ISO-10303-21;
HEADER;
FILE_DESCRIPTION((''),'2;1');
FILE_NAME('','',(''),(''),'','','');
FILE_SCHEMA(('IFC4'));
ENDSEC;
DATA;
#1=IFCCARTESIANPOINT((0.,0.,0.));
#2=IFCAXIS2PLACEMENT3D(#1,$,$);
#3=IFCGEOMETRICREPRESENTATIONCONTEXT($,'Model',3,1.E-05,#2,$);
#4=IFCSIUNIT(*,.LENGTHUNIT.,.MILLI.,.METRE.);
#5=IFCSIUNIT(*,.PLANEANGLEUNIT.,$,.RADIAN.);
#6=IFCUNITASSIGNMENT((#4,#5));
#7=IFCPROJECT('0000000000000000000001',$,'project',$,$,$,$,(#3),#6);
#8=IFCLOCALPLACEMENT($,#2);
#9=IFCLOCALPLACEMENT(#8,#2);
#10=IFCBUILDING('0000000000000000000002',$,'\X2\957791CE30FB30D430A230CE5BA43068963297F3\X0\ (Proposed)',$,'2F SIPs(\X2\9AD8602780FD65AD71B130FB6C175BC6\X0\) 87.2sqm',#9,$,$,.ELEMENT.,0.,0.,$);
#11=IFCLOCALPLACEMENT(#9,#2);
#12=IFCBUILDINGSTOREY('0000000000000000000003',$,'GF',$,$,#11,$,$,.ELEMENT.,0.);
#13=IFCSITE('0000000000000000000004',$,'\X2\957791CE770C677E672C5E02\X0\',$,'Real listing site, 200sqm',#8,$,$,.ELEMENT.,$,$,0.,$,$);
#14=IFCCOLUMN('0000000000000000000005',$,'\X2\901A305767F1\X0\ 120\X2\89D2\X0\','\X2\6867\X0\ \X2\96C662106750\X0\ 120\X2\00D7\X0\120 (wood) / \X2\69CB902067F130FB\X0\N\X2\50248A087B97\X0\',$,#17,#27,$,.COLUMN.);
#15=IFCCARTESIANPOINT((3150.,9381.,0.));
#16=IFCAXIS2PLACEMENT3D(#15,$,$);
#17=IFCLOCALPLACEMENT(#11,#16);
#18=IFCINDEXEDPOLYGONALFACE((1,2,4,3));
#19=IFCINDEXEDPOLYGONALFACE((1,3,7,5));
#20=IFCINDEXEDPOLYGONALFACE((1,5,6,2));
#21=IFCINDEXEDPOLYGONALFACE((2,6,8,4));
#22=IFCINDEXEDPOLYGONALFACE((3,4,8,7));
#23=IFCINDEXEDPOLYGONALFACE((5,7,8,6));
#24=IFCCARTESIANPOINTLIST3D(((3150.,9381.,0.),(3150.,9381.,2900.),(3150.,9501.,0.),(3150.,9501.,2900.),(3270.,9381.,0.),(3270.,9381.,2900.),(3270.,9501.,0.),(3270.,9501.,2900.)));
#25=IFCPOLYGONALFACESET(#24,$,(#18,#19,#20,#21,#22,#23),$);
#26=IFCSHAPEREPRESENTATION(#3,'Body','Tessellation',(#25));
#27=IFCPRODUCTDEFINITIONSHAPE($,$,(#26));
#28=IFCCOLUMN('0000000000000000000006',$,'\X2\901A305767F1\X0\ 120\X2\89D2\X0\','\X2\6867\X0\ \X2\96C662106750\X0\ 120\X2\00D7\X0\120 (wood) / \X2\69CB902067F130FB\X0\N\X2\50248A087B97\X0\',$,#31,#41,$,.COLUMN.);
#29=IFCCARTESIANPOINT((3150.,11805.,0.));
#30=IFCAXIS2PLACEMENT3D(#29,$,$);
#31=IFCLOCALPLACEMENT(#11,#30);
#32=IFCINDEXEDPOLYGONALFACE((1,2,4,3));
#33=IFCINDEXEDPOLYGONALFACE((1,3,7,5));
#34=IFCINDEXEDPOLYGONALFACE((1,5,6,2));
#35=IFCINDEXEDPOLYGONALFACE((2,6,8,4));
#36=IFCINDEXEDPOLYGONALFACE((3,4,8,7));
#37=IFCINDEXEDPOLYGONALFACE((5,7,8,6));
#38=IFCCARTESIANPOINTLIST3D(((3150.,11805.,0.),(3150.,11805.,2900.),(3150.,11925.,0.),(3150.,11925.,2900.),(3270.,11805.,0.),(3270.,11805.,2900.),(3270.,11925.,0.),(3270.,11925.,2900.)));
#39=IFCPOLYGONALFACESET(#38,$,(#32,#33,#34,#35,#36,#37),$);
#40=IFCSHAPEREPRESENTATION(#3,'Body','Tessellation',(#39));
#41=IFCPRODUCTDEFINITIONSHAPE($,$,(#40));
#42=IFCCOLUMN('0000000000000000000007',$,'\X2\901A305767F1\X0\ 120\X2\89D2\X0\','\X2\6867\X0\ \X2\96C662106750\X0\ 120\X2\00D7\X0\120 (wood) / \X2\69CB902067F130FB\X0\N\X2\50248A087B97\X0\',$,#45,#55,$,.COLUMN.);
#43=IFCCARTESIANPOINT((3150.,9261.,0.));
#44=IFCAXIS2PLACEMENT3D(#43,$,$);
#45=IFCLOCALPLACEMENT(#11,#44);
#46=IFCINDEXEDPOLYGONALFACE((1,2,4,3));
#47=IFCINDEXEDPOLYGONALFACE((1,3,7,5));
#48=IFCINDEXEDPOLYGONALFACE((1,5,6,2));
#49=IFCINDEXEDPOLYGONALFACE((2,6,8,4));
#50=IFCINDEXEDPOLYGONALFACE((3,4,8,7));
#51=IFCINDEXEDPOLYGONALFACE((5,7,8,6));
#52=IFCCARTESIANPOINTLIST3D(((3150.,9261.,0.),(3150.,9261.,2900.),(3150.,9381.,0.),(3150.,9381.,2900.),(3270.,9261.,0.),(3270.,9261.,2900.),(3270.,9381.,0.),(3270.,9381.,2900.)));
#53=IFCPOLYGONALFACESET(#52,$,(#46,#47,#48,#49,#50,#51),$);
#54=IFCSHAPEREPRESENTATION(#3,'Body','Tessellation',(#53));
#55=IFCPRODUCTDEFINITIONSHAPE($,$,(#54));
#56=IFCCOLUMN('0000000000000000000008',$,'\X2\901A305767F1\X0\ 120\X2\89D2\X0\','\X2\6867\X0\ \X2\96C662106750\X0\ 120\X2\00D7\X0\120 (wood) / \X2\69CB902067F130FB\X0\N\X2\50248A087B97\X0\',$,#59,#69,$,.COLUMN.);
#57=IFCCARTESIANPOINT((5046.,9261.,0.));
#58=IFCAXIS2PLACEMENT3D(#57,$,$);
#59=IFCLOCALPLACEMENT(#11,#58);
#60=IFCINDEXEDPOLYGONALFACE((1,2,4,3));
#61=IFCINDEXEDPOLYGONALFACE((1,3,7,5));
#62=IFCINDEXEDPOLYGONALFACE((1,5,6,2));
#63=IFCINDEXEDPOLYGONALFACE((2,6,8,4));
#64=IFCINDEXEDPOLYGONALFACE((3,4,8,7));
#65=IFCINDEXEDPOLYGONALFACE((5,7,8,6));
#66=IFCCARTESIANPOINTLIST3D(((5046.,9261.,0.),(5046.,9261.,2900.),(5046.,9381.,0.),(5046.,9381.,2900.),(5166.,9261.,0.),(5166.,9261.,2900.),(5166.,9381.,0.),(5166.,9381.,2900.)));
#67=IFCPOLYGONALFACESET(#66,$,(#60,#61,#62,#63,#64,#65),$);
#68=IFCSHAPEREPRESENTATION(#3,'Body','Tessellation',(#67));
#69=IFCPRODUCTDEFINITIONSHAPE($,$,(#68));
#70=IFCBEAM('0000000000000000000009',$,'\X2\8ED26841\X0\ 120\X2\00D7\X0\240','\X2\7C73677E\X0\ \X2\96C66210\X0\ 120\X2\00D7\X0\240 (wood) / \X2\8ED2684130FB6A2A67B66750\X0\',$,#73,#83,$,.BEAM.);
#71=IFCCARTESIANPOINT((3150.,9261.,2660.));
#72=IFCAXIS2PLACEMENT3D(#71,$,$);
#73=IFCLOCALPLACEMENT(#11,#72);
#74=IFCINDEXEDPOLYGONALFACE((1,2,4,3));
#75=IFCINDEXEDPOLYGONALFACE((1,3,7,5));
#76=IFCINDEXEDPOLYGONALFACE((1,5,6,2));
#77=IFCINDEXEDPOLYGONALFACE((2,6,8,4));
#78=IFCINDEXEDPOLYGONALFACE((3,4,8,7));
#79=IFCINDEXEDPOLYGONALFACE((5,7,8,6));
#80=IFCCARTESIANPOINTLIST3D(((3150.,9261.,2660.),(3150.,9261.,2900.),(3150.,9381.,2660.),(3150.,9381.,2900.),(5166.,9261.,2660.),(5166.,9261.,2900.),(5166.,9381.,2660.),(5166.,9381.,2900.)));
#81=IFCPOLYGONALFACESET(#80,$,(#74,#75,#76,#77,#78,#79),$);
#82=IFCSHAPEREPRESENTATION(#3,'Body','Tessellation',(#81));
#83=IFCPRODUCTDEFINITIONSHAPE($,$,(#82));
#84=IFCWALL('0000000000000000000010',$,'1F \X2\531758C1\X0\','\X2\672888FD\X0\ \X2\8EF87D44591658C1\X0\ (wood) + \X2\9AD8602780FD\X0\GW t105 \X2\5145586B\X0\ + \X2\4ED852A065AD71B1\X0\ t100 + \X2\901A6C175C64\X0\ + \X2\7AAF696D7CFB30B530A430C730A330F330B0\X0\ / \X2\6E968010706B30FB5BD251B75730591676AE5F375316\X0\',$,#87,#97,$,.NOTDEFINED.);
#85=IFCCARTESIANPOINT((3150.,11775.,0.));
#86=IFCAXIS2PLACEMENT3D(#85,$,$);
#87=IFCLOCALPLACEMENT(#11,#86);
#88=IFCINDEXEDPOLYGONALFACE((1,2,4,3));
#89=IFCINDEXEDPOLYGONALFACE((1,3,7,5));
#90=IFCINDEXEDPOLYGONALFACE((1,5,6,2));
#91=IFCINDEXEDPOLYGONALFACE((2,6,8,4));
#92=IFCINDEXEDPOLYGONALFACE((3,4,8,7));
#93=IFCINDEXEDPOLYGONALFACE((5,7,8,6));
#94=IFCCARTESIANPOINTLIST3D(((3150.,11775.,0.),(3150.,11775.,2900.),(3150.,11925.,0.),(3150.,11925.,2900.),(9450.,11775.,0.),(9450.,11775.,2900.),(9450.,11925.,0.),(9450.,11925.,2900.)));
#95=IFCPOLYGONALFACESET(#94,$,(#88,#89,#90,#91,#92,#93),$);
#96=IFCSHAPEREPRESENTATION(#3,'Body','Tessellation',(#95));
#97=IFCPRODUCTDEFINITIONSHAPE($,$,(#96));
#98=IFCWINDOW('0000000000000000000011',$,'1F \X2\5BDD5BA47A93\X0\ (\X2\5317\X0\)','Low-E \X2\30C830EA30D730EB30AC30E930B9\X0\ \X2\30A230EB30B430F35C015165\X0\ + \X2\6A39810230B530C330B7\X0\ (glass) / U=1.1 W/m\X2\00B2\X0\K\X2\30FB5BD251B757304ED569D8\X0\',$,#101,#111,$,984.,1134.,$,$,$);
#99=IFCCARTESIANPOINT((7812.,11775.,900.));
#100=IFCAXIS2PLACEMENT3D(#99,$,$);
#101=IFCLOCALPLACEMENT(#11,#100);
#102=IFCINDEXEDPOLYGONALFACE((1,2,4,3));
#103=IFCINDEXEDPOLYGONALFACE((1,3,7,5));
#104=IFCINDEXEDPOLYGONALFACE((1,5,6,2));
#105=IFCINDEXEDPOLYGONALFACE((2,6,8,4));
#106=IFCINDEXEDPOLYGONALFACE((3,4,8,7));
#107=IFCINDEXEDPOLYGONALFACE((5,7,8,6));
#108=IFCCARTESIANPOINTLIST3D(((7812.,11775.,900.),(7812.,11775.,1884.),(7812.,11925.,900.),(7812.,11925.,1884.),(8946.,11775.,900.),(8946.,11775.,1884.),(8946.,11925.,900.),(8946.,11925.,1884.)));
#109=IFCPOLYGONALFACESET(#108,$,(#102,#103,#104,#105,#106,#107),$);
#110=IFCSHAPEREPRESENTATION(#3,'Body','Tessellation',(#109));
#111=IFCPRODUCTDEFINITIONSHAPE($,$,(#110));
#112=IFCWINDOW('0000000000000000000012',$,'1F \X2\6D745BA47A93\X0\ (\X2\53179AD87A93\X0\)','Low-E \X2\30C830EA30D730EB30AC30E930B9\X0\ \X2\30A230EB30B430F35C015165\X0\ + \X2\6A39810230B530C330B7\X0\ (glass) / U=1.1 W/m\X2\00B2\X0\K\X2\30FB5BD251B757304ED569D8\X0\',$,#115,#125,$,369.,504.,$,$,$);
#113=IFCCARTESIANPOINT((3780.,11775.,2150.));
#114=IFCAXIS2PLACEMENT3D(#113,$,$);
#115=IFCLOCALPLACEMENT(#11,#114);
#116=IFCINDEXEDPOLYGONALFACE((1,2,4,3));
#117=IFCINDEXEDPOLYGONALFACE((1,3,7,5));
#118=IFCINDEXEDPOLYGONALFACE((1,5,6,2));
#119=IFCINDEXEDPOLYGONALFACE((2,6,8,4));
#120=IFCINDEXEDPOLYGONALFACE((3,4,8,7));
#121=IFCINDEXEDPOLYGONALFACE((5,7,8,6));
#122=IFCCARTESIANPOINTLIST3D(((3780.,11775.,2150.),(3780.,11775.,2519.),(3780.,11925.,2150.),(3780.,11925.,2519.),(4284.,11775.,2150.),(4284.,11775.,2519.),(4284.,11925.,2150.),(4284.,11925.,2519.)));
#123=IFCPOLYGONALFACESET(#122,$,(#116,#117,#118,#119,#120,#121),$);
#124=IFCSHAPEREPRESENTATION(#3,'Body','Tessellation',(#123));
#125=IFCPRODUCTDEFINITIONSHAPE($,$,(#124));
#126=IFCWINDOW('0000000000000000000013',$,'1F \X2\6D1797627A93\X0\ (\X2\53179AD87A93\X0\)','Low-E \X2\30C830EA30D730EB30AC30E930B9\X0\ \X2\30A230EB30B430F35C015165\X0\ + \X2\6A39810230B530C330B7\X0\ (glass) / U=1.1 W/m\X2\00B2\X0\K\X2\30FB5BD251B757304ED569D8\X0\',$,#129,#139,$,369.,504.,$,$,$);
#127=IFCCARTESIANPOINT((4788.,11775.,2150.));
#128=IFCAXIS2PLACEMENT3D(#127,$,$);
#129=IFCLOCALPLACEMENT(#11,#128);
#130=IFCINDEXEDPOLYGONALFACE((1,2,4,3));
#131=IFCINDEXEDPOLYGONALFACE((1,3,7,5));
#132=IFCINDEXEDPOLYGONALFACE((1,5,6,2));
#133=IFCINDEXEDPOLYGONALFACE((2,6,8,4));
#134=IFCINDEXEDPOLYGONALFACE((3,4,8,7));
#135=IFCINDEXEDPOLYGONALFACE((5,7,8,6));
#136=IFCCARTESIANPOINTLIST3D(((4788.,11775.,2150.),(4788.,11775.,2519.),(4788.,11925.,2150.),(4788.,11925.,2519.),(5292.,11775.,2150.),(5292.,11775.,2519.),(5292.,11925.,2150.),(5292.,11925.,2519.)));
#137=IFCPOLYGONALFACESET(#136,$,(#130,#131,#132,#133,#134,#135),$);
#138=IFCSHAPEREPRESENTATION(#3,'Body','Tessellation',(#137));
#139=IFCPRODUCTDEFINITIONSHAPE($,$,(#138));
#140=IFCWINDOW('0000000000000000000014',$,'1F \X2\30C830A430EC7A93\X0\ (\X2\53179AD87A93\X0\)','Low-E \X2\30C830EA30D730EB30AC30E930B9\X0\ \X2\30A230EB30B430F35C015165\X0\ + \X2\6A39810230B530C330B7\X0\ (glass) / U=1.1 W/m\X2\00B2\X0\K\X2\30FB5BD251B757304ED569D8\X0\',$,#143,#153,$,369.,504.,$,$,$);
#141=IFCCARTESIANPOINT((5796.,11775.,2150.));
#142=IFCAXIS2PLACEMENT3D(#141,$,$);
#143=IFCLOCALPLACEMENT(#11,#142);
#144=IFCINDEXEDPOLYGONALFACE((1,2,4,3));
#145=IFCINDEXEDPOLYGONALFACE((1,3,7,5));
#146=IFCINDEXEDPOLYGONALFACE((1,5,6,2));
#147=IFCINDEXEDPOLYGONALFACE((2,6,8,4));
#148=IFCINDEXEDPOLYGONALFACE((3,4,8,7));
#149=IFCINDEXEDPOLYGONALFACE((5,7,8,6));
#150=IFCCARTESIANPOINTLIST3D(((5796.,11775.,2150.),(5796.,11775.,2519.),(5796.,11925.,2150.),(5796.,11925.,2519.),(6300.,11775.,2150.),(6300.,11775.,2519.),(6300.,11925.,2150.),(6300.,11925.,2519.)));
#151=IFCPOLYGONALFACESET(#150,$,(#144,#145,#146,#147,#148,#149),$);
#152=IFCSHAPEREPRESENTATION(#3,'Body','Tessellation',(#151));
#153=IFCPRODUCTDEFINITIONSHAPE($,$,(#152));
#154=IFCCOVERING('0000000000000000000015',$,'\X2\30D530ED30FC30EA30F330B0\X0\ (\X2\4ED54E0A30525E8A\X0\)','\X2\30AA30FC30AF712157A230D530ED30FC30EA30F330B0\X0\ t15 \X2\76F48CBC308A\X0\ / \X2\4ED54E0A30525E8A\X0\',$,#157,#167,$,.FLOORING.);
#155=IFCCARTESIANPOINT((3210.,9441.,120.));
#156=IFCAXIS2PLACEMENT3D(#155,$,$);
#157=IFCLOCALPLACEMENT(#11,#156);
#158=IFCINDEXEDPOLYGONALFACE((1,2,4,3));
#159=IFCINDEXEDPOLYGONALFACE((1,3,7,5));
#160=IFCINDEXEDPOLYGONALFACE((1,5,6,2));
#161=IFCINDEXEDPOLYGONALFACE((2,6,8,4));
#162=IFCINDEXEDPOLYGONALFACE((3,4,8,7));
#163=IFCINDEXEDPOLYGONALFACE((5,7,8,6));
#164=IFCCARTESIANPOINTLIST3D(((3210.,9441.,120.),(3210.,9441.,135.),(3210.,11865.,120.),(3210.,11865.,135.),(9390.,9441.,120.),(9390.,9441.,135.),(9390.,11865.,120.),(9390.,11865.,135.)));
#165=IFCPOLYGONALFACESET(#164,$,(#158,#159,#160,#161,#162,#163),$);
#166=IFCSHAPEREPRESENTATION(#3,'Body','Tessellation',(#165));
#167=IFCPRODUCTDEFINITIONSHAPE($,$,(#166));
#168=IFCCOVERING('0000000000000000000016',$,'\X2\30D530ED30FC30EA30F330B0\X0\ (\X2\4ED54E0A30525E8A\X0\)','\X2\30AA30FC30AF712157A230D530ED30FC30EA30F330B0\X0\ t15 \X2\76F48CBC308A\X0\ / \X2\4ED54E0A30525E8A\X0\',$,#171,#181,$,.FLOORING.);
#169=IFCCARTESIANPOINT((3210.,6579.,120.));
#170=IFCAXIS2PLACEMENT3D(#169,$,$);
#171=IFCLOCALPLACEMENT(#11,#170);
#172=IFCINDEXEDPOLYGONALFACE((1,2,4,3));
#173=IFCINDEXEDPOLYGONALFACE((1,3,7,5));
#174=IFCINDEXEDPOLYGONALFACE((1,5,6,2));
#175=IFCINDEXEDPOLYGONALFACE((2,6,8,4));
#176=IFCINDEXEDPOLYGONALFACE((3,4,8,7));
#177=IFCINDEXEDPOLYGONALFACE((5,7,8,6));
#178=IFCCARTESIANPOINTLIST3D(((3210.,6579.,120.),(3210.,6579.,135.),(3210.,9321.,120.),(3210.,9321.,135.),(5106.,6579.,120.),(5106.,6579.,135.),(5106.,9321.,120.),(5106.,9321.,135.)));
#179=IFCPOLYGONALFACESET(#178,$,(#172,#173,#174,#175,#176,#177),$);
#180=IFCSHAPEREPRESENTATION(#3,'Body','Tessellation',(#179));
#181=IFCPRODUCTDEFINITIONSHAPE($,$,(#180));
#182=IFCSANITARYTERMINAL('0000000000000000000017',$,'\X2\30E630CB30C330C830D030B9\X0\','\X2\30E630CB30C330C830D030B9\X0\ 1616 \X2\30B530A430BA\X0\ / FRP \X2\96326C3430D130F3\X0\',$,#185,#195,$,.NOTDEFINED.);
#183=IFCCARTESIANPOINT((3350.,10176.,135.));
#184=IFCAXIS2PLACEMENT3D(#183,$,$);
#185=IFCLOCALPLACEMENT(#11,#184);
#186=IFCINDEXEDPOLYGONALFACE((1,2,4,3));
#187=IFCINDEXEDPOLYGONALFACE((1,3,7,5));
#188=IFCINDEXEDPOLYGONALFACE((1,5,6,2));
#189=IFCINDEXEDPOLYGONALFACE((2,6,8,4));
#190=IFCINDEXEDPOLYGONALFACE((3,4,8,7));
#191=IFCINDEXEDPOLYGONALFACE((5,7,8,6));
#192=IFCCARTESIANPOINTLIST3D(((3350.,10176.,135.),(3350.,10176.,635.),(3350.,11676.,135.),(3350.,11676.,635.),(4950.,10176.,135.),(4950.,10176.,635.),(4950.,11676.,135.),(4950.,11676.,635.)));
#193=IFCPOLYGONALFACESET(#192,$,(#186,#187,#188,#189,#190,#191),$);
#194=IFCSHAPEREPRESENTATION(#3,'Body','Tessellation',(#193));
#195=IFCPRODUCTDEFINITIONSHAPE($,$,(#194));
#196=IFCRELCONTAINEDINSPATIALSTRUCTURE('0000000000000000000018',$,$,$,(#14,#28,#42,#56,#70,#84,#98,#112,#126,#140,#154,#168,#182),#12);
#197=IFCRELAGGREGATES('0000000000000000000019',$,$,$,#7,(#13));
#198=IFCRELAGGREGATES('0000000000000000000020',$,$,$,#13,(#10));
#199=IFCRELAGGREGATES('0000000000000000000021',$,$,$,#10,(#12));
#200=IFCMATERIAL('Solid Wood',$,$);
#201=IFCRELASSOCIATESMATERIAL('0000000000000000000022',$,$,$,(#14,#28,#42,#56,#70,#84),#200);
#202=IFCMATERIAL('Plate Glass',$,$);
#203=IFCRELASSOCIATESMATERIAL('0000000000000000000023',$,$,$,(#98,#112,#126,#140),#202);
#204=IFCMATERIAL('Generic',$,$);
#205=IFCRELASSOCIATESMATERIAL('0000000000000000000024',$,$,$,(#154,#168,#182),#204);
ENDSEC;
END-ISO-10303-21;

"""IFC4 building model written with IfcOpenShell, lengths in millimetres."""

from ifc_helpers import new_model, si_unit, frame, frame_2d, origin, place, context, project, spatial, rectangle, extrude, material, element, fill, save


model = new_model("IFC4")

# Units and contexts
model_context = context("Model", 3, precision=1e-05, world=origin())
ifc_project = project(units=[si_unit("LENGTHUNIT", "METRE", prefix="MILLI"), si_unit("PLANEANGLEUNIT", "RADIAN")], contexts=[model_context])

# Site, building, storey
site_placement = place(None, origin())
site = spatial("IfcSite", under=ifc_project, at=site_placement, Name="長野県松本市", ObjectType="Real listing site, 200sqm", CompositionType="ELEMENT", RefElevation=0.0)
building_placement = place(site_placement, origin())
building = spatial("IfcBuilding", under=site, at=building_placement, Name="長野・ピアノ室と防音 (Proposed)", ObjectType="2F SIPs(高性能断熱・気密) 87.2sqm", CompositionType="ELEMENT", ElevationOfRefHeight=0.0, ElevationOfTerrain=0.0)
storey_placement = place(building_placement, origin())
storey = spatial("IfcBuildingStorey", under=building, at=storey_placement, Name="GF", CompositionType="ELEMENT", Elevation=0.0)

# Columns
ifc_material_1 = material(Name="Solid Wood")
column_1_placement = place(storey_placement, frame((3150.0, 9381.0, 0.0)))
element("IfcColumn", 1, at=column_1_placement, inside=storey, material=ifc_material_1, Name="通し柱 120角", Description="桧 集成材 120×120 (wood) / 構造柱・N値計算", PredefinedType="COLUMN", context=model_context, shape_type="SweptSolid", body=[
    extrude(rectangle(XDim=120.0, YDim=120.0, at=frame_2d((60.0, 60.0))), frame((3150.0, 9381.0, 0.0)), (0.0, 0.0, 1.0), 2900.0),
])
column_2_placement = place(storey_placement, frame((3150.0, 11805.0, 0.0)))
element("IfcColumn", 2, at=column_2_placement, inside=storey, material=ifc_material_1, Name="通し柱 120角", Description="桧 集成材 120×120 (wood) / 構造柱・N値計算", PredefinedType="COLUMN", context=model_context, shape_type="SweptSolid", body=[
    extrude(rectangle(XDim=120.0, YDim=120.0, at=frame_2d((60.0, 60.0))), frame((3150.0, 11805.0, 0.0)), (0.0, 0.0, 1.0), 2900.0),
])
column_3_placement = place(storey_placement, frame((3150.0, 9261.0, 0.0)))
element("IfcColumn", 3, at=column_3_placement, inside=storey, material=ifc_material_1, Name="通し柱 120角", Description="桧 集成材 120×120 (wood) / 構造柱・N値計算", PredefinedType="COLUMN", context=model_context, shape_type="SweptSolid", body=[
    extrude(rectangle(XDim=120.0, YDim=120.0, at=frame_2d((60.0, 60.0))), frame((3150.0, 9261.0, 0.0)), (0.0, 0.0, 1.0), 2900.0),
])
column_4_placement = place(storey_placement, frame((5046.0, 9261.0, 0.0)))
element("IfcColumn", 4, at=column_4_placement, inside=storey, material=ifc_material_1, Name="通し柱 120角", Description="桧 集成材 120×120 (wood) / 構造柱・N値計算", PredefinedType="COLUMN", context=model_context, shape_type="SweptSolid", body=[
    extrude(rectangle(XDim=120.0, YDim=120.0, at=frame_2d((60.0, 60.0))), frame((5046.0, 9261.0, 0.0)), (0.0, 0.0, 1.0), 2900.0),
])

# Beam
beam_1_placement = place(storey_placement, frame((3150.0, 9261.0, 2660.0)))
element("IfcBeam", 5, at=beam_1_placement, inside=storey, material=ifc_material_1, Name="軒桁 120×240", Description="米松 集成 120×240 (wood) / 軒桁・横架材", PredefinedType="BEAM", context=model_context, shape_type="SweptSolid", body=[
    extrude(rectangle(XDim=2016.0, YDim=120.0, at=frame_2d((1008.0, 60.0))), frame((3150.0, 9261.0, 2660.0)), (0.0, 0.0, 1.0), 240.0),
])

# Wall, openings, windows
wall_1_placement = place(storey_placement, frame((3150.0, 11775.0, 0.0)))
wall_1 = element("IfcWall", 6, at=wall_1_placement, inside=storey, material=ifc_material_1, Name="1F 北壁", Description="木製 軸組外壁 (wood) + 高性能GW t105 充填 + 付加断熱 t100 + 通気層 + 窯業系サイディング / 準耐火・寒冷地外皮強化", PredefinedType="NOTDEFINED", context=model_context, shape_type="SweptSolid", body=[
    extrude(rectangle(XDim=6300.0, YDim=150.0, at=frame_2d((3150.0, 75.0))), frame((3150.0, 11775.0, 0.0)), (0.0, 0.0, 1.0), 2900.0),
])
opening_1_placement = place(storey_placement, frame((7812.0, 11775.0, 900.0)))
opening_1 = element("IfcOpeningElement", 7, at=opening_1_placement, cuts=wall_1, PredefinedType="NOTDEFINED", context=model_context, shape_type="SweptSolid", body=[
    extrude(rectangle(XDim=1134.0, YDim=150.0, at=frame_2d((567.0, 75.0))), frame((7812.0, 11775.0, 900.0)), (0.0, 0.0, 1.0), 984.0),
])
opening_2_placement = place(storey_placement, frame((3780.0, 11775.0, 2150.0)))
opening_2 = element("IfcOpeningElement", 8, at=opening_2_placement, cuts=wall_1, PredefinedType="NOTDEFINED", context=model_context, shape_type="SweptSolid", body=[
    extrude(rectangle(XDim=504.0, YDim=150.0, at=frame_2d((252.0, 75.0))), frame((3780.0, 11775.0, 2150.0)), (0.0, 0.0, 1.0), 369.0),
])
opening_3_placement = place(storey_placement, frame((4788.0, 11775.0, 2150.0)))
opening_3 = element("IfcOpeningElement", 9, at=opening_3_placement, cuts=wall_1, PredefinedType="NOTDEFINED", context=model_context, shape_type="SweptSolid", body=[
    extrude(rectangle(XDim=504.0, YDim=150.0, at=frame_2d((252.0, 75.0))), frame((4788.0, 11775.0, 2150.0)), (0.0, 0.0, 1.0), 369.0),
])
opening_4_placement = place(storey_placement, frame((5796.0, 11775.0, 2150.0)))
opening_4 = element("IfcOpeningElement", 10, at=opening_4_placement, cuts=wall_1, PredefinedType="NOTDEFINED", context=model_context, shape_type="SweptSolid", body=[
    extrude(rectangle(XDim=504.0, YDim=150.0, at=frame_2d((252.0, 75.0))), frame((5796.0, 11775.0, 2150.0)), (0.0, 0.0, 1.0), 369.0),
])
ifc_material_2 = material(Name="Plate Glass")
window_1_placement = place(storey_placement, frame((7812.0, 11775.0, 900.0)))
window_1 = element("IfcWindow", 11, at=window_1_placement, inside=storey, material=ifc_material_2, Name="1F 寝室窓 (北)", Description="Low-E トリプルガラス アルゴン封入 + 樹脂サッシ (glass) / U=1.1 W/m²K・寒冷地仕様", OverallHeight=984.0, OverallWidth=1134.0, context=model_context, shape_type="SweptSolid", body=[
    extrude(rectangle(XDim=1134.0, YDim=150.0, at=frame_2d((567.0, 75.0))), frame((7812.0, 11775.0, 900.0)), (0.0, 0.0, 1.0), 984.0),
])
fill(opening_1, window_1)
window_2_placement = place(storey_placement, frame((3780.0, 11775.0, 2150.0)))
window_2 = element("IfcWindow", 12, at=window_2_placement, inside=storey, material=ifc_material_2, Name="1F 浴室窓 (北高窓)", Description="Low-E トリプルガラス アルゴン封入 + 樹脂サッシ (glass) / U=1.1 W/m²K・寒冷地仕様", OverallHeight=369.0, OverallWidth=504.0, context=model_context, shape_type="SweptSolid", body=[
    extrude(rectangle(XDim=504.0, YDim=150.0, at=frame_2d((252.0, 75.0))), frame((3780.0, 11775.0, 2150.0)), (0.0, 0.0, 1.0), 369.0),
])
fill(opening_2, window_2)
window_3_placement = place(storey_placement, frame((4788.0, 11775.0, 2150.0)))
window_3 = element("IfcWindow", 13, at=window_3_placement, inside=storey, material=ifc_material_2, Name="1F 洗面窓 (北高窓)", Description="Low-E トリプルガラス アルゴン封入 + 樹脂サッシ (glass) / U=1.1 W/m²K・寒冷地仕様", OverallHeight=369.0, OverallWidth=504.0, context=model_context, shape_type="SweptSolid", body=[
    extrude(rectangle(XDim=504.0, YDim=150.0, at=frame_2d((252.0, 75.0))), frame((4788.0, 11775.0, 2150.0)), (0.0, 0.0, 1.0), 369.0),
])
fill(opening_3, window_3)
window_4_placement = place(storey_placement, frame((5796.0, 11775.0, 2150.0)))
window_4 = element("IfcWindow", 14, at=window_4_placement, inside=storey, material=ifc_material_2, Name="1F トイレ窓 (北高窓)", Description="Low-E トリプルガラス アルゴン封入 + 樹脂サッシ (glass) / U=1.1 W/m²K・寒冷地仕様", OverallHeight=369.0, OverallWidth=504.0, context=model_context, shape_type="SweptSolid", body=[
    extrude(rectangle(XDim=504.0, YDim=150.0, at=frame_2d((252.0, 75.0))), frame((5796.0, 11775.0, 2150.0)), (0.0, 0.0, 1.0), 369.0),
])
fill(opening_4, window_4)

# Coverings
ifc_material_3 = material(Name="Generic")
covering_1_placement = place(storey_placement, frame((3210.0, 9441.0, 120.0)))
element("IfcCovering", 15, at=covering_1_placement, inside=storey, material=ifc_material_3, Name="フローリング (仕上げ床)", Description="オーク無垢フローリング t15 直貼り / 仕上げ床", PredefinedType="FLOORING", context=model_context, shape_type="SweptSolid", body=[
    extrude(rectangle(XDim=6180.0, YDim=2424.0, at=frame_2d((3090.0, 1212.0))), frame((3210.0, 9441.0, 120.0)), (0.0, 0.0, 1.0), 15.0),
])
covering_2_placement = place(storey_placement, frame((3210.0, 6579.0, 120.0)))
element("IfcCovering", 16, at=covering_2_placement, inside=storey, material=ifc_material_3, Name="フローリング (仕上げ床)", Description="オーク無垢フローリング t15 直貼り / 仕上げ床", PredefinedType="FLOORING", context=model_context, shape_type="SweptSolid", body=[
    extrude(rectangle(XDim=1896.0, YDim=2742.0, at=frame_2d((948.0, 1371.0))), frame((3210.0, 6579.0, 120.0)), (0.0, 0.0, 1.0), 15.0),
])

# Sanitary terminal
sanitary_terminal_1_placement = place(storey_placement, frame((3350.0, 10176.0, 135.0)))
element("IfcSanitaryTerminal", 17, at=sanitary_terminal_1_placement, inside=storey, material=ifc_material_3, Name="ユニットバス", Description="ユニットバス 1616 サイズ / FRP 防水パン", PredefinedType="NOTDEFINED", context=model_context, shape_type="SweptSolid", body=[
    extrude(rectangle(XDim=1600.0, YDim=1500.0, at=frame_2d((800.0, 750.0))), frame((3350.0, 10176.0, 135.0)), (0.0, 0.0, 1.0), 500.0),
])

save(model, "model.ifc")
